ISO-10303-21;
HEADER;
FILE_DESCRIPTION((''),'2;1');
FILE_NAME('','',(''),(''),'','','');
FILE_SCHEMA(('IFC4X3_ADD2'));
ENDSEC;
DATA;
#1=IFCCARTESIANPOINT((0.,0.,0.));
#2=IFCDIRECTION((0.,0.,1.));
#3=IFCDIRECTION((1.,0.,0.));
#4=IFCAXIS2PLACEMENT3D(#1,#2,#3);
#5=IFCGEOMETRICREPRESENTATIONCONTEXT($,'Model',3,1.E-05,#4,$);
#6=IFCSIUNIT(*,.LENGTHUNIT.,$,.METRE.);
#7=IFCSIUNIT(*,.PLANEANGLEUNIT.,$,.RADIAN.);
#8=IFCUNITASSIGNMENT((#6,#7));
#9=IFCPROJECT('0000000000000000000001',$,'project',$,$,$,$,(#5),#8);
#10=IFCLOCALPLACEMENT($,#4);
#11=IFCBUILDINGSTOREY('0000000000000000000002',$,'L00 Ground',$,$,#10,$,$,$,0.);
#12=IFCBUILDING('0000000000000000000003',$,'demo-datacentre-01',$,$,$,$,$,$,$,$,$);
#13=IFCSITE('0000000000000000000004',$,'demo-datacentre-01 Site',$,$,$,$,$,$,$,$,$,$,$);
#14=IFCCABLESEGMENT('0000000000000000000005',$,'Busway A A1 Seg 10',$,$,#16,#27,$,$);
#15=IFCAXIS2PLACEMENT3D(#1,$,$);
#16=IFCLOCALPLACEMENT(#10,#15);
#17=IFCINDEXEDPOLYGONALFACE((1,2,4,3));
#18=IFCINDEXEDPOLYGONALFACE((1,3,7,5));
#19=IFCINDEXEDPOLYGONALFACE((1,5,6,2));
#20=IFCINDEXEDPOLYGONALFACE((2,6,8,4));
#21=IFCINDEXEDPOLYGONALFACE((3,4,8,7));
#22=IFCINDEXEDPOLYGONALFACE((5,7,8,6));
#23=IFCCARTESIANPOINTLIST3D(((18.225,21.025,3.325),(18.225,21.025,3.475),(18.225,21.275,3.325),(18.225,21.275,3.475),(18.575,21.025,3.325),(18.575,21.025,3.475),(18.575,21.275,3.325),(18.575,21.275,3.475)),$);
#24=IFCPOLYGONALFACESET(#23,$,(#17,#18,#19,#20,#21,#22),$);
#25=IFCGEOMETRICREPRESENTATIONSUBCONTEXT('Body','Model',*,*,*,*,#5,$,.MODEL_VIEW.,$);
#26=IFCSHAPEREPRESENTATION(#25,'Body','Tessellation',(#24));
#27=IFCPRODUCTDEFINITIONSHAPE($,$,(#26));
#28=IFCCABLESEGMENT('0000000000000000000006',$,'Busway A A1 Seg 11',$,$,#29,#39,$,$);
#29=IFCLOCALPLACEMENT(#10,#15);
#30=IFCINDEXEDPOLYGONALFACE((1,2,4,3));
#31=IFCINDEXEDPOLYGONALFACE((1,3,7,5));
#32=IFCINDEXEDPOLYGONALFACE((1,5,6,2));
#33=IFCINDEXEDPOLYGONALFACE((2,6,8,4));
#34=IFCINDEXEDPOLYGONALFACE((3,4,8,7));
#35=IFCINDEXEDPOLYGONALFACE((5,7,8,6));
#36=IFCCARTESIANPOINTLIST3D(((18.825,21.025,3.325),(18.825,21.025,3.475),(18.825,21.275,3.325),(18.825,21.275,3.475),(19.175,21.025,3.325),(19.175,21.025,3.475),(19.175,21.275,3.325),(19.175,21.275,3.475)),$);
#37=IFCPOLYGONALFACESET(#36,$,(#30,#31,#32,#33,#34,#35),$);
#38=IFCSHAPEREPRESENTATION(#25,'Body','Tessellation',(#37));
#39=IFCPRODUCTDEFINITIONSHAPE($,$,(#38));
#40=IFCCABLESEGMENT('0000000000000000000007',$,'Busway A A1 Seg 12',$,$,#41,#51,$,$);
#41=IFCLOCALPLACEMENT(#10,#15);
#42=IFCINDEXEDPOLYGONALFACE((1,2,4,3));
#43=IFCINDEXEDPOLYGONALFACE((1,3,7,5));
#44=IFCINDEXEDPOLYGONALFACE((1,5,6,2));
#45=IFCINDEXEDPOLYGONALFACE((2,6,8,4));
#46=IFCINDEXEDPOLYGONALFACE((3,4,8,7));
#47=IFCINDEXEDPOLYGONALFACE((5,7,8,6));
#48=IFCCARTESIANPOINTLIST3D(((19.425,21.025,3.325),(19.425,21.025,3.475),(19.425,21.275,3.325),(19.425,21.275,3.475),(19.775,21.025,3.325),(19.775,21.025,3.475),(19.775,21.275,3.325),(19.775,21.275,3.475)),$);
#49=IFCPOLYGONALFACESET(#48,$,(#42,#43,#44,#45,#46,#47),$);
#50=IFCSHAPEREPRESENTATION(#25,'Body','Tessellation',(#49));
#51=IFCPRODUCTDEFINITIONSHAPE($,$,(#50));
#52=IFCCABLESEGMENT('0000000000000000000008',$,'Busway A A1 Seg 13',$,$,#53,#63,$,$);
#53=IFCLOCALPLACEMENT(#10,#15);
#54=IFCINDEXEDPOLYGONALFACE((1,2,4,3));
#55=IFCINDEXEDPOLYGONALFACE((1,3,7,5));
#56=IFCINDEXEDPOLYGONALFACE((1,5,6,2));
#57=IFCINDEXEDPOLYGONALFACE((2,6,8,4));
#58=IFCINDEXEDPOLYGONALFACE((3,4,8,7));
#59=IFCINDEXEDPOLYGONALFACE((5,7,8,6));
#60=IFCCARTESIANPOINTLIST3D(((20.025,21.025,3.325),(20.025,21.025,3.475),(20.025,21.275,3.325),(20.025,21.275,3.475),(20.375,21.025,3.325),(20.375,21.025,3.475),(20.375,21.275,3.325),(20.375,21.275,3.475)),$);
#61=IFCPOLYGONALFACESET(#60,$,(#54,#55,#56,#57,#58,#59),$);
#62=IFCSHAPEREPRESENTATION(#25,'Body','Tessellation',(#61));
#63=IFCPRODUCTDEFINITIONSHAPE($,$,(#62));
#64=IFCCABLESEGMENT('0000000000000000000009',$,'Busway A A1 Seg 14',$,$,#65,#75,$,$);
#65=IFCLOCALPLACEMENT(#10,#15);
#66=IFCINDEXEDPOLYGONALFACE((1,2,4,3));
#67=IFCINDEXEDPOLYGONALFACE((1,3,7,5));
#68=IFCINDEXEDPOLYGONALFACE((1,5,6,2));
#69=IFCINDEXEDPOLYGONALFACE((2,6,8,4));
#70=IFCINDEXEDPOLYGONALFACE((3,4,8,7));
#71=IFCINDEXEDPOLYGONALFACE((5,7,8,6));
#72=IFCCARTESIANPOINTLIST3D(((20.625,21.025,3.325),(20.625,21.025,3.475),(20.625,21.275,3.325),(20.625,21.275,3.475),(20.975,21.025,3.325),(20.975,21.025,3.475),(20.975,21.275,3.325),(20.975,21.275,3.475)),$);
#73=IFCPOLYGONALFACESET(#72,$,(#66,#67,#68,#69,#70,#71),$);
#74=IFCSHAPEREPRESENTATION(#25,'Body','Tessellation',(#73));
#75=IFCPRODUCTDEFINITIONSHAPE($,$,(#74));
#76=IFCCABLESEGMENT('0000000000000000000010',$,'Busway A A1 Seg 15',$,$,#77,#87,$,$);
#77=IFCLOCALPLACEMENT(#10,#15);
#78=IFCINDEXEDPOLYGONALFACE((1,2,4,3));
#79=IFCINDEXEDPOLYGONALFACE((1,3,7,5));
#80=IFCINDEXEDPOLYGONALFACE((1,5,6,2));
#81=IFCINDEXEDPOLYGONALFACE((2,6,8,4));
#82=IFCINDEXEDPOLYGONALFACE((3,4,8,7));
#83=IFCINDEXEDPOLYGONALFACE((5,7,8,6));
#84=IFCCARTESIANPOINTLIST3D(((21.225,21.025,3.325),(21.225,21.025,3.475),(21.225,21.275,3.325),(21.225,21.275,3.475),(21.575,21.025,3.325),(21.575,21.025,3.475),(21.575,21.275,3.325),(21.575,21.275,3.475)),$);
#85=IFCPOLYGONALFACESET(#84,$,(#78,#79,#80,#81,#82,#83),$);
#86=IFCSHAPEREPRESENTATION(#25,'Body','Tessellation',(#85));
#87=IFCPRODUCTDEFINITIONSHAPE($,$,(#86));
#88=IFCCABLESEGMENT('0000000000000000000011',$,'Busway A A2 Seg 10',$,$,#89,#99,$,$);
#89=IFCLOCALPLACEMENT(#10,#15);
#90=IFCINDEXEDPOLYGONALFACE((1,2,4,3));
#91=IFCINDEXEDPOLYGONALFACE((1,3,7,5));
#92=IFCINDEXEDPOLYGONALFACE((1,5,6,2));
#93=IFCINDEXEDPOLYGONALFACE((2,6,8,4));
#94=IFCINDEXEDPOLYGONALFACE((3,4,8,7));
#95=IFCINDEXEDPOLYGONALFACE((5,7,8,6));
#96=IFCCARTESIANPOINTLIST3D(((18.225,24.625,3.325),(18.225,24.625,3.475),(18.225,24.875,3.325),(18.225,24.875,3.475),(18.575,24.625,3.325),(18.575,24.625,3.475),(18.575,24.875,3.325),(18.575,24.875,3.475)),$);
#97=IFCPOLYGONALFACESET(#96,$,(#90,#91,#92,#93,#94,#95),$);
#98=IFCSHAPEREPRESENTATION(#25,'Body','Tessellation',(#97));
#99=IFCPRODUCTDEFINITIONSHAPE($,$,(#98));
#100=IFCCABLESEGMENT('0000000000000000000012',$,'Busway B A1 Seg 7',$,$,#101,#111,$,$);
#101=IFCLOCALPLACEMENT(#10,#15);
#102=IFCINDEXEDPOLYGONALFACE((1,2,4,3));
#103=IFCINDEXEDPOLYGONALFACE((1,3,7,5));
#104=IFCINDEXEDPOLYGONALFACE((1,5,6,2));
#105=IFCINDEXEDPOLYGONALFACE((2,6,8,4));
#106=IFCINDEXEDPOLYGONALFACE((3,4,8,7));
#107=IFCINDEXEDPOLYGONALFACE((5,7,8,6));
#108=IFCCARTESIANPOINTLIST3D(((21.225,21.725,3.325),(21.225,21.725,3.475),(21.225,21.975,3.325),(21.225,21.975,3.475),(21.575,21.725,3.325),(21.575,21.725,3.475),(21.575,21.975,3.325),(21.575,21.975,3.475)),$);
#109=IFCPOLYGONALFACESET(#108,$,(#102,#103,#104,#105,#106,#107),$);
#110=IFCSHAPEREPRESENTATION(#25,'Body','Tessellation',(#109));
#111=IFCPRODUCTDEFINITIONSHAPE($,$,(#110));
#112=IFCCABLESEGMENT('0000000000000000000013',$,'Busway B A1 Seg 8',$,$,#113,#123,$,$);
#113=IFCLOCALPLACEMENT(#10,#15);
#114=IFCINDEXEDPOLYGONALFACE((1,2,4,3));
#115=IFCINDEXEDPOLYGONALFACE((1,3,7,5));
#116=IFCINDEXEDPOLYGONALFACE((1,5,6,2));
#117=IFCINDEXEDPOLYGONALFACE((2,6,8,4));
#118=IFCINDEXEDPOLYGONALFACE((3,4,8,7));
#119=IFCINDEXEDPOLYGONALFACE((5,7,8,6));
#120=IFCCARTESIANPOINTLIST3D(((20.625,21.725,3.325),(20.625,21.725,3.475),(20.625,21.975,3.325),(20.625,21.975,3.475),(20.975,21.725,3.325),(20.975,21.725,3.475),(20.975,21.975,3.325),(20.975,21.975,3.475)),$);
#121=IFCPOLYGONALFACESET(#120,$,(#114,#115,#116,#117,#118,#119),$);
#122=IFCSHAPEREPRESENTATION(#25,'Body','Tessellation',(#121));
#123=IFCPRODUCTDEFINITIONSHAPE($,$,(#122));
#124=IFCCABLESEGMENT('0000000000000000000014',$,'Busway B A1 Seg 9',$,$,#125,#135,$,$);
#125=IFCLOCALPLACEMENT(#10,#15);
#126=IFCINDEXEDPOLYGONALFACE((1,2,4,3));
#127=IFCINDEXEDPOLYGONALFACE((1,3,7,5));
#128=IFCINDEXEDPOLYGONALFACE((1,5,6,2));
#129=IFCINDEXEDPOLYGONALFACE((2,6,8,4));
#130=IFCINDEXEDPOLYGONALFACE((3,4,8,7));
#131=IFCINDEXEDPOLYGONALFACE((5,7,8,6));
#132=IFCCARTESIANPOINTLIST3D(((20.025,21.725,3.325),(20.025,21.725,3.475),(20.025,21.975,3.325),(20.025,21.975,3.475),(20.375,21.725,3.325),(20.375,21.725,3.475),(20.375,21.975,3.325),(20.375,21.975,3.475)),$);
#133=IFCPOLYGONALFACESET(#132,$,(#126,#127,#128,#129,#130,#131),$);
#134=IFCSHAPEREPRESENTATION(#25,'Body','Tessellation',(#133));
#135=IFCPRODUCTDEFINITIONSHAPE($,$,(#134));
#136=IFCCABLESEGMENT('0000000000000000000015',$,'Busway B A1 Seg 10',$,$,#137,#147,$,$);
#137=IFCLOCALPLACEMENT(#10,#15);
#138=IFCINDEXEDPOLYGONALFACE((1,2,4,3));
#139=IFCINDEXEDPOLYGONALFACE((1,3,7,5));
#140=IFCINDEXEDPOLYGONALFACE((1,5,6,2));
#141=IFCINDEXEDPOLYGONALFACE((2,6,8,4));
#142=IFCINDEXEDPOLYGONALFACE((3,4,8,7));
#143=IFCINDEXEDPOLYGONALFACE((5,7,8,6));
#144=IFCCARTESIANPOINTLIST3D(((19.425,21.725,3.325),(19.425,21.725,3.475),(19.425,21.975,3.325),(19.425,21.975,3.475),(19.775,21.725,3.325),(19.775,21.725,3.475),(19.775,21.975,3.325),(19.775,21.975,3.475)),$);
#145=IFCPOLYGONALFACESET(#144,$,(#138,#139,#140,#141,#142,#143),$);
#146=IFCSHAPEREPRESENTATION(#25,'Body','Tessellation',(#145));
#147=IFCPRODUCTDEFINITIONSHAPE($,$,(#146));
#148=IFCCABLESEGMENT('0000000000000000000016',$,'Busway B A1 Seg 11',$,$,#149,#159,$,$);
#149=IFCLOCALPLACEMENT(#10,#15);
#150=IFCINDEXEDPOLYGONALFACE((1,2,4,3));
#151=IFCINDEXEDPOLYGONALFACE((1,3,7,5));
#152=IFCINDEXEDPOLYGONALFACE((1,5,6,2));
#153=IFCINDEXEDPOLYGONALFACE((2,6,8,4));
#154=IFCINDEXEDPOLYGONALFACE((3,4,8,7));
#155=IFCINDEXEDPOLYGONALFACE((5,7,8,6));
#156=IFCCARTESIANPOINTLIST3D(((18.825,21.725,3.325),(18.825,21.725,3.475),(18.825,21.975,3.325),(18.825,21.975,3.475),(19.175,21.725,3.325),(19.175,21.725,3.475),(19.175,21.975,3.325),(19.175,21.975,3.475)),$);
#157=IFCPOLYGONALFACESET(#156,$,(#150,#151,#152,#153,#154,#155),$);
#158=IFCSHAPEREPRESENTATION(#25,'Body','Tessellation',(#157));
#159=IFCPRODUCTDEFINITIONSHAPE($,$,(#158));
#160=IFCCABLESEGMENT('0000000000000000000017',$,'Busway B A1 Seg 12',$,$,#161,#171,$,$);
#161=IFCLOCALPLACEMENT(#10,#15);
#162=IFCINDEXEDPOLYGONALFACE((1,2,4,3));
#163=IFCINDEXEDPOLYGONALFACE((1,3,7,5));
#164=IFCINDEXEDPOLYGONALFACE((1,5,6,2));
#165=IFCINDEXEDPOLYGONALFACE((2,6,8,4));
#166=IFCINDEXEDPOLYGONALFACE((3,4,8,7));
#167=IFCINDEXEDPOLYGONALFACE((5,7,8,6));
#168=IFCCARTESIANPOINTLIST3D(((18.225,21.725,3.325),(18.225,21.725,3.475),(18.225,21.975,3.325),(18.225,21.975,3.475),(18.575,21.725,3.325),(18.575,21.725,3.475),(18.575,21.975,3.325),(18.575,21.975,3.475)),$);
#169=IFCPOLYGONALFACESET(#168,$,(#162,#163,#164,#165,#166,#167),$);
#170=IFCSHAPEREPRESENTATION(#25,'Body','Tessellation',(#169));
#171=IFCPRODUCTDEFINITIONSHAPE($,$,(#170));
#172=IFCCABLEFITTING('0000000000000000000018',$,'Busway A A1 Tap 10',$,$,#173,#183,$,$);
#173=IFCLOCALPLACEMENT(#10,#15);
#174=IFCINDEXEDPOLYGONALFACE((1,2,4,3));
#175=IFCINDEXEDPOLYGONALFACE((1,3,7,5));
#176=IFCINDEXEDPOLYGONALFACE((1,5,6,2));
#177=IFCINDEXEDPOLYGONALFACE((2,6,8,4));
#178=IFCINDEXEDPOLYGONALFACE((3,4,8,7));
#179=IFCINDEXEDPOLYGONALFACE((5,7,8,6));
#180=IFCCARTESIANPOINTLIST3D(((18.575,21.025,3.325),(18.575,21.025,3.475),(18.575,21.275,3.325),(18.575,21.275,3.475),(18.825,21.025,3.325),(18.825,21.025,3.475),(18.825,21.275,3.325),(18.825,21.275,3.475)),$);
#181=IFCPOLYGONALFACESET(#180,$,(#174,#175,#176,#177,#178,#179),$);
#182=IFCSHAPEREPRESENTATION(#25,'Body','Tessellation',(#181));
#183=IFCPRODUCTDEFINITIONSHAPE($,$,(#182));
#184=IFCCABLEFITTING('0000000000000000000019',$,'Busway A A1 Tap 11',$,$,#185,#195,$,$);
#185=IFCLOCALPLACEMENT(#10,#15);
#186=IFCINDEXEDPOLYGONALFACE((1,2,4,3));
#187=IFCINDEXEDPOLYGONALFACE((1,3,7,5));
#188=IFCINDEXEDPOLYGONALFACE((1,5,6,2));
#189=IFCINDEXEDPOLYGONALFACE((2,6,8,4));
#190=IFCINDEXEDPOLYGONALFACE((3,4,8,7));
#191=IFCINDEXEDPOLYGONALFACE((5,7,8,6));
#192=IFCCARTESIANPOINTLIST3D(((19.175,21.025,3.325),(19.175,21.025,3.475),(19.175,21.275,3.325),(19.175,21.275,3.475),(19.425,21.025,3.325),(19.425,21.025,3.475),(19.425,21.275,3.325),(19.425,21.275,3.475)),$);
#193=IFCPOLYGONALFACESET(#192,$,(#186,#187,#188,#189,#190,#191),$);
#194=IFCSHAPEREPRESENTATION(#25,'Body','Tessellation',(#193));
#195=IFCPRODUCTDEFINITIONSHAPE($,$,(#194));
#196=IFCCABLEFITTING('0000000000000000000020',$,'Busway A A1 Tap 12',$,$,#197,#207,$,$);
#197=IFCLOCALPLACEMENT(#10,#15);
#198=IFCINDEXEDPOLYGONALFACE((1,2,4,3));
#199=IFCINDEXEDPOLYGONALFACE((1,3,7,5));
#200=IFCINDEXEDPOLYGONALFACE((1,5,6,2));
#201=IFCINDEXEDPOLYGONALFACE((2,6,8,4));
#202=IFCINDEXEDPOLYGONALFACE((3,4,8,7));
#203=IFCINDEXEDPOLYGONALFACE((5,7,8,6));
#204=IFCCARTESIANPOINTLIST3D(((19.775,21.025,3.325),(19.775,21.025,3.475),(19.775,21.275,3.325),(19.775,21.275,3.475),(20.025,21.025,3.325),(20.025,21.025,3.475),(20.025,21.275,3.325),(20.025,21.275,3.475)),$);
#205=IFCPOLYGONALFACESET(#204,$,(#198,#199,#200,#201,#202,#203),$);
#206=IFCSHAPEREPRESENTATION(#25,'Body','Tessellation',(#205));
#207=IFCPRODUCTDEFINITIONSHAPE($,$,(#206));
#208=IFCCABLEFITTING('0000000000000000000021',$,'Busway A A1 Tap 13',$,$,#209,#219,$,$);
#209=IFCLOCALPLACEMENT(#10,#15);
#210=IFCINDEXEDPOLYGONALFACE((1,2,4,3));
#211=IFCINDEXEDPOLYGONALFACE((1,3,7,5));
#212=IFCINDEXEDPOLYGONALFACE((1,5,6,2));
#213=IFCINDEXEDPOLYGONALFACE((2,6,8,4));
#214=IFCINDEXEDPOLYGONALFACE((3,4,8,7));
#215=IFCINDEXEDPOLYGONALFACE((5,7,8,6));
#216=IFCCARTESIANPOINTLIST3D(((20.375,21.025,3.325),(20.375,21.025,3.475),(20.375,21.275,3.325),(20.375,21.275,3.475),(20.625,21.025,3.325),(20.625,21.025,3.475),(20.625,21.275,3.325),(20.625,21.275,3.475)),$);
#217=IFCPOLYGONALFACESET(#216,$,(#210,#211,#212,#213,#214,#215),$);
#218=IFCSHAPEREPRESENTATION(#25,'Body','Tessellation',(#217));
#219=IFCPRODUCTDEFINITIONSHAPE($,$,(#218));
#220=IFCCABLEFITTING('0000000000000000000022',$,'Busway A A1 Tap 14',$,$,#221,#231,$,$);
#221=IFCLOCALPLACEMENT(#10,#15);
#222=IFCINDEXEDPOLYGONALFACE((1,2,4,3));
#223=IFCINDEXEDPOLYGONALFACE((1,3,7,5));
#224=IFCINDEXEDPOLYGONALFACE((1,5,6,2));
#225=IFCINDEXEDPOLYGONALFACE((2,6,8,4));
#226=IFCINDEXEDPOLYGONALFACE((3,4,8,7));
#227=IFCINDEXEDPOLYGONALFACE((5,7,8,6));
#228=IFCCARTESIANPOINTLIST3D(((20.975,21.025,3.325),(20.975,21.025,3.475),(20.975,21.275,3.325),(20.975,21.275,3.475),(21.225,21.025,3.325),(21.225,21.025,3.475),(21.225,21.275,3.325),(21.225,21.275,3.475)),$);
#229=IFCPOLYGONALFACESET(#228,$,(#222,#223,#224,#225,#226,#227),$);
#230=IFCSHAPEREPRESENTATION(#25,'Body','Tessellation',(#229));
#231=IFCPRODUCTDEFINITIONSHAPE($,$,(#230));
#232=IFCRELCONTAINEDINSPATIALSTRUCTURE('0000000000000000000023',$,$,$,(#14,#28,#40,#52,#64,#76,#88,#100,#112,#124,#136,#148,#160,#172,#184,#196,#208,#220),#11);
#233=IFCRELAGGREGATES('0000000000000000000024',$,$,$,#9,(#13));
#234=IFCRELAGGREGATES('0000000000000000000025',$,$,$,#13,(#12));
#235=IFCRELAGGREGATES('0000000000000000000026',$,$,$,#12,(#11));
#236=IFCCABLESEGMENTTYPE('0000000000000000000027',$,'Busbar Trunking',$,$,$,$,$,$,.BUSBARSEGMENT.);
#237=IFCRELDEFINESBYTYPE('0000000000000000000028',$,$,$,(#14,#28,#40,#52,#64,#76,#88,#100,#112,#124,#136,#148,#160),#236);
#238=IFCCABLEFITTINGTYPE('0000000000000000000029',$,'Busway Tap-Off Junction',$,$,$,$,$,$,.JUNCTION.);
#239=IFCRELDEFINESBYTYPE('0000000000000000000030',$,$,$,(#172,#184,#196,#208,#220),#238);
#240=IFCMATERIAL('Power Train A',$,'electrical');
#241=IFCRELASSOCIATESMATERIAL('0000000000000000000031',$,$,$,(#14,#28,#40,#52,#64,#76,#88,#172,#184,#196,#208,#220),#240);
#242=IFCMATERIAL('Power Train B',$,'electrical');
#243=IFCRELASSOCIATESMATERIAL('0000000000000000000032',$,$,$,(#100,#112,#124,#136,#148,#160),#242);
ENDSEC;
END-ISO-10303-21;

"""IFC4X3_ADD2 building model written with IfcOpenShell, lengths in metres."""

from ifc_helpers import new_model, si_unit, frame, origin_with_axes, place, context, subcontext, project, spatial, rectangle, extrude, material, type_object, element, save


model = new_model("IFC4X3_ADD2")

# Units and contexts
model_context = context("Model", 3, precision=1e-05, world=origin_with_axes())
body_context = subcontext(model_context, "Body", "Model", "MODEL_VIEW")
ifc_project = project(units=[si_unit("LENGTHUNIT", "METRE"), si_unit("PLANEANGLEUNIT", "RADIAN")], contexts=[model_context])

# Site, building, storey
site = spatial("IfcSite", under=ifc_project, Name="demo-datacentre-01 Site")
building = spatial("IfcBuilding", under=site, Name="demo-datacentre-01")
storey_placement = place(None, origin_with_axes())
storey = spatial("IfcBuildingStorey", under=building, at=storey_placement, Name="L00 Ground", Elevation=0.0)

# Cable segments
ifc_material_1 = material(Name="Power Train A", Category="electrical")
cable_segment_type_1 = type_object("IfcCableSegmentType", Name="Busbar Trunking", PredefinedType="BUSBARSEGMENT")
cable_segment_1_placement = place(storey_placement, frame((18.225, 21.15, 3.4), z_axis=(1.0, 0.0, 0.0), x_axis=(0.0, 1.0, 0.0)))
element("IfcCableSegment", 1, at=cable_segment_1_placement, inside=storey, type_object=cable_segment_type_1, material=ifc_material_1, Name="Busway A A1 Seg 10", context=body_context, shape_type="SweptSolid", body=[
    extrude(rectangle(XDim=0.25, YDim=0.15), origin_with_axes(), (0.0, 0.0, 1.0), 0.35),
])
cable_segment_2_placement = place(storey_placement, frame((18.825, 21.15, 3.4), z_axis=(1.0, 0.0, 0.0), x_axis=(0.0, 1.0, 0.0)))
element("IfcCableSegment", 2, at=cable_segment_2_placement, inside=storey, type_object=cable_segment_type_1, material=ifc_material_1, Name="Busway A A1 Seg 11", context=body_context, shape_type="SweptSolid", body=[
    extrude(rectangle(XDim=0.25, YDim=0.15), origin_with_axes(), (0.0, 0.0, 1.0), 0.35),
])
cable_segment_3_placement = place(storey_placement, frame((19.425, 21.15, 3.4), z_axis=(1.0, 0.0, 0.0), x_axis=(0.0, 1.0, 0.0)))
element("IfcCableSegment", 3, at=cable_segment_3_placement, inside=storey, type_object=cable_segment_type_1, material=ifc_material_1, Name="Busway A A1 Seg 12", context=body_context, shape_type="SweptSolid", body=[
    extrude(rectangle(XDim=0.25, YDim=0.15), origin_with_axes(), (0.0, 0.0, 1.0), 0.35),
])
for number, where, z_axis, x_axis, name in (
    (4, (20.025, 21.15, 3.4), (1.0, 0.0, 0.0), (0.0, 1.0, 0.0), "Busway A A1 Seg 13"),
    (5, (20.625, 21.15, 3.4), (1.0, 0.0, 0.0), (0.0, 1.0, 0.0), "Busway A A1 Seg 14"),
    (6, (21.225, 21.15, 3.4), (1.0, 0.0, 0.0), (0.0, 1.0, 0.0), "Busway A A1 Seg 15"),
):
    element("IfcCableSegment", number, at=place(storey_placement, frame(where, z_axis=z_axis, x_axis=x_axis)), inside=storey, type_object=cable_segment_type_1, material=ifc_material_1, Name=name, context=body_context, shape_type="SweptSolid", body=[
        extrude(rectangle(XDim=0.25, YDim=0.15), origin_with_axes(), (0.0, 0.0, 1.0), 0.35),
    ])
cable_segment_4_placement = place(storey_placement, frame((18.225, 24.75, 3.4), z_axis=(1.0, 0.0, 0.0), x_axis=(0.0, 1.0, 0.0)))
element("IfcCableSegment", 7, at=cable_segment_4_placement, inside=storey, type_object=cable_segment_type_1, material=ifc_material_1, Name="Busway A A2 Seg 10", context=body_context, shape_type="SweptSolid", body=[
    extrude(rectangle(XDim=0.25, YDim=0.15), origin_with_axes(), (0.0, 0.0, 1.0), 0.35),
])
ifc_material_2 = material(Name="Power Train B", Category="electrical")
for number, where, z_axis, x_axis, name in (
    (8, (21.575, 21.85, 3.4), (-1.0, 0.0, 0.0), (0.0, -1.0, 0.0), "Busway B A1 Seg 7"),
    (9, (20.975, 21.85, 3.4), (-1.0, 0.0, 0.0), (0.0, -1.0, 0.0), "Busway B A1 Seg 8"),
    (10, (20.375, 21.85, 3.4), (-1.0, 0.0, 0.0), (0.0, -1.0, 0.0), "Busway B A1 Seg 9"),
):
    element("IfcCableSegment", number, at=place(storey_placement, frame(where, z_axis=z_axis, x_axis=x_axis)), inside=storey, type_object=cable_segment_type_1, material=ifc_material_2, Name=name, context=body_context, shape_type="SweptSolid", body=[
        extrude(rectangle(XDim=0.25, YDim=0.15), origin_with_axes(), (0.0, 0.0, 1.0), 0.35),
    ])
cable_segment_5_placement = place(storey_placement, frame((19.775, 21.85, 3.4), z_axis=(-1.0, 0.0, 0.0), x_axis=(0.0, -1.0, 0.0)))
element("IfcCableSegment", 11, at=cable_segment_5_placement, inside=storey, type_object=cable_segment_type_1, material=ifc_material_2, Name="Busway B A1 Seg 10", context=body_context, shape_type="SweptSolid", body=[
    extrude(rectangle(XDim=0.25, YDim=0.15), origin_with_axes(), (0.0, 0.0, 1.0), 0.35),
])
cable_segment_6_placement = place(storey_placement, frame((19.175, 21.85, 3.4), z_axis=(-1.0, 0.0, 0.0), x_axis=(0.0, -1.0, 0.0)))
element("IfcCableSegment", 12, at=cable_segment_6_placement, inside=storey, type_object=cable_segment_type_1, material=ifc_material_2, Name="Busway B A1 Seg 11", context=body_context, shape_type="SweptSolid", body=[
    extrude(rectangle(XDim=0.25, YDim=0.15), origin_with_axes(), (0.0, 0.0, 1.0), 0.35),
])
cable_segment_7_placement = place(storey_placement, frame((18.575, 21.85, 3.4), z_axis=(-1.0, 0.0, 0.0), x_axis=(0.0, -1.0, 0.0)))
element("IfcCableSegment", 13, at=cable_segment_7_placement, inside=storey, type_object=cable_segment_type_1, material=ifc_material_2, Name="Busway B A1 Seg 12", context=body_context, shape_type="SweptSolid", body=[
    extrude(rectangle(XDim=0.25, YDim=0.15), origin_with_axes(), (0.0, 0.0, 1.0), 0.35),
])

# Cable fittings
cable_fitting_type = type_object("IfcCableFittingType", Name="Busway Tap-Off Junction", PredefinedType="JUNCTION")
for number, where, z_axis, x_axis, name in (
    (14, (18.7, 21.15, 3.325), (0.0, 0.0, 1.0), (1.0, 0.0, 0.0), "Busway A A1 Tap 10"),
    (15, (19.3, 21.15, 3.325), (0.0, 0.0, 1.0), (1.0, 0.0, 0.0), "Busway A A1 Tap 11"),
    (16, (19.9, 21.15, 3.325), (0.0, 0.0, 1.0), (1.0, 0.0, 0.0), "Busway A A1 Tap 12"),
    (17, (20.5, 21.15, 3.325), (0.0, 0.0, 1.0), (1.0, 0.0, 0.0), "Busway A A1 Tap 13"),
    (18, (21.1, 21.15, 3.325), (0.0, 0.0, 1.0), (1.0, 0.0, 0.0), "Busway A A1 Tap 14"),
):
    element("IfcCableFitting", number, at=place(storey_placement, frame(where, z_axis=z_axis, x_axis=x_axis)), inside=storey, type_object=cable_fitting_type, material=ifc_material_1, Name=name, context=body_context, shape_type="SweptSolid", body=[
        extrude(rectangle(XDim=0.25, YDim=0.25), origin_with_axes(), (0.0, 0.0, 1.0), 0.15),
    ])

save(model, "model.ifc")
